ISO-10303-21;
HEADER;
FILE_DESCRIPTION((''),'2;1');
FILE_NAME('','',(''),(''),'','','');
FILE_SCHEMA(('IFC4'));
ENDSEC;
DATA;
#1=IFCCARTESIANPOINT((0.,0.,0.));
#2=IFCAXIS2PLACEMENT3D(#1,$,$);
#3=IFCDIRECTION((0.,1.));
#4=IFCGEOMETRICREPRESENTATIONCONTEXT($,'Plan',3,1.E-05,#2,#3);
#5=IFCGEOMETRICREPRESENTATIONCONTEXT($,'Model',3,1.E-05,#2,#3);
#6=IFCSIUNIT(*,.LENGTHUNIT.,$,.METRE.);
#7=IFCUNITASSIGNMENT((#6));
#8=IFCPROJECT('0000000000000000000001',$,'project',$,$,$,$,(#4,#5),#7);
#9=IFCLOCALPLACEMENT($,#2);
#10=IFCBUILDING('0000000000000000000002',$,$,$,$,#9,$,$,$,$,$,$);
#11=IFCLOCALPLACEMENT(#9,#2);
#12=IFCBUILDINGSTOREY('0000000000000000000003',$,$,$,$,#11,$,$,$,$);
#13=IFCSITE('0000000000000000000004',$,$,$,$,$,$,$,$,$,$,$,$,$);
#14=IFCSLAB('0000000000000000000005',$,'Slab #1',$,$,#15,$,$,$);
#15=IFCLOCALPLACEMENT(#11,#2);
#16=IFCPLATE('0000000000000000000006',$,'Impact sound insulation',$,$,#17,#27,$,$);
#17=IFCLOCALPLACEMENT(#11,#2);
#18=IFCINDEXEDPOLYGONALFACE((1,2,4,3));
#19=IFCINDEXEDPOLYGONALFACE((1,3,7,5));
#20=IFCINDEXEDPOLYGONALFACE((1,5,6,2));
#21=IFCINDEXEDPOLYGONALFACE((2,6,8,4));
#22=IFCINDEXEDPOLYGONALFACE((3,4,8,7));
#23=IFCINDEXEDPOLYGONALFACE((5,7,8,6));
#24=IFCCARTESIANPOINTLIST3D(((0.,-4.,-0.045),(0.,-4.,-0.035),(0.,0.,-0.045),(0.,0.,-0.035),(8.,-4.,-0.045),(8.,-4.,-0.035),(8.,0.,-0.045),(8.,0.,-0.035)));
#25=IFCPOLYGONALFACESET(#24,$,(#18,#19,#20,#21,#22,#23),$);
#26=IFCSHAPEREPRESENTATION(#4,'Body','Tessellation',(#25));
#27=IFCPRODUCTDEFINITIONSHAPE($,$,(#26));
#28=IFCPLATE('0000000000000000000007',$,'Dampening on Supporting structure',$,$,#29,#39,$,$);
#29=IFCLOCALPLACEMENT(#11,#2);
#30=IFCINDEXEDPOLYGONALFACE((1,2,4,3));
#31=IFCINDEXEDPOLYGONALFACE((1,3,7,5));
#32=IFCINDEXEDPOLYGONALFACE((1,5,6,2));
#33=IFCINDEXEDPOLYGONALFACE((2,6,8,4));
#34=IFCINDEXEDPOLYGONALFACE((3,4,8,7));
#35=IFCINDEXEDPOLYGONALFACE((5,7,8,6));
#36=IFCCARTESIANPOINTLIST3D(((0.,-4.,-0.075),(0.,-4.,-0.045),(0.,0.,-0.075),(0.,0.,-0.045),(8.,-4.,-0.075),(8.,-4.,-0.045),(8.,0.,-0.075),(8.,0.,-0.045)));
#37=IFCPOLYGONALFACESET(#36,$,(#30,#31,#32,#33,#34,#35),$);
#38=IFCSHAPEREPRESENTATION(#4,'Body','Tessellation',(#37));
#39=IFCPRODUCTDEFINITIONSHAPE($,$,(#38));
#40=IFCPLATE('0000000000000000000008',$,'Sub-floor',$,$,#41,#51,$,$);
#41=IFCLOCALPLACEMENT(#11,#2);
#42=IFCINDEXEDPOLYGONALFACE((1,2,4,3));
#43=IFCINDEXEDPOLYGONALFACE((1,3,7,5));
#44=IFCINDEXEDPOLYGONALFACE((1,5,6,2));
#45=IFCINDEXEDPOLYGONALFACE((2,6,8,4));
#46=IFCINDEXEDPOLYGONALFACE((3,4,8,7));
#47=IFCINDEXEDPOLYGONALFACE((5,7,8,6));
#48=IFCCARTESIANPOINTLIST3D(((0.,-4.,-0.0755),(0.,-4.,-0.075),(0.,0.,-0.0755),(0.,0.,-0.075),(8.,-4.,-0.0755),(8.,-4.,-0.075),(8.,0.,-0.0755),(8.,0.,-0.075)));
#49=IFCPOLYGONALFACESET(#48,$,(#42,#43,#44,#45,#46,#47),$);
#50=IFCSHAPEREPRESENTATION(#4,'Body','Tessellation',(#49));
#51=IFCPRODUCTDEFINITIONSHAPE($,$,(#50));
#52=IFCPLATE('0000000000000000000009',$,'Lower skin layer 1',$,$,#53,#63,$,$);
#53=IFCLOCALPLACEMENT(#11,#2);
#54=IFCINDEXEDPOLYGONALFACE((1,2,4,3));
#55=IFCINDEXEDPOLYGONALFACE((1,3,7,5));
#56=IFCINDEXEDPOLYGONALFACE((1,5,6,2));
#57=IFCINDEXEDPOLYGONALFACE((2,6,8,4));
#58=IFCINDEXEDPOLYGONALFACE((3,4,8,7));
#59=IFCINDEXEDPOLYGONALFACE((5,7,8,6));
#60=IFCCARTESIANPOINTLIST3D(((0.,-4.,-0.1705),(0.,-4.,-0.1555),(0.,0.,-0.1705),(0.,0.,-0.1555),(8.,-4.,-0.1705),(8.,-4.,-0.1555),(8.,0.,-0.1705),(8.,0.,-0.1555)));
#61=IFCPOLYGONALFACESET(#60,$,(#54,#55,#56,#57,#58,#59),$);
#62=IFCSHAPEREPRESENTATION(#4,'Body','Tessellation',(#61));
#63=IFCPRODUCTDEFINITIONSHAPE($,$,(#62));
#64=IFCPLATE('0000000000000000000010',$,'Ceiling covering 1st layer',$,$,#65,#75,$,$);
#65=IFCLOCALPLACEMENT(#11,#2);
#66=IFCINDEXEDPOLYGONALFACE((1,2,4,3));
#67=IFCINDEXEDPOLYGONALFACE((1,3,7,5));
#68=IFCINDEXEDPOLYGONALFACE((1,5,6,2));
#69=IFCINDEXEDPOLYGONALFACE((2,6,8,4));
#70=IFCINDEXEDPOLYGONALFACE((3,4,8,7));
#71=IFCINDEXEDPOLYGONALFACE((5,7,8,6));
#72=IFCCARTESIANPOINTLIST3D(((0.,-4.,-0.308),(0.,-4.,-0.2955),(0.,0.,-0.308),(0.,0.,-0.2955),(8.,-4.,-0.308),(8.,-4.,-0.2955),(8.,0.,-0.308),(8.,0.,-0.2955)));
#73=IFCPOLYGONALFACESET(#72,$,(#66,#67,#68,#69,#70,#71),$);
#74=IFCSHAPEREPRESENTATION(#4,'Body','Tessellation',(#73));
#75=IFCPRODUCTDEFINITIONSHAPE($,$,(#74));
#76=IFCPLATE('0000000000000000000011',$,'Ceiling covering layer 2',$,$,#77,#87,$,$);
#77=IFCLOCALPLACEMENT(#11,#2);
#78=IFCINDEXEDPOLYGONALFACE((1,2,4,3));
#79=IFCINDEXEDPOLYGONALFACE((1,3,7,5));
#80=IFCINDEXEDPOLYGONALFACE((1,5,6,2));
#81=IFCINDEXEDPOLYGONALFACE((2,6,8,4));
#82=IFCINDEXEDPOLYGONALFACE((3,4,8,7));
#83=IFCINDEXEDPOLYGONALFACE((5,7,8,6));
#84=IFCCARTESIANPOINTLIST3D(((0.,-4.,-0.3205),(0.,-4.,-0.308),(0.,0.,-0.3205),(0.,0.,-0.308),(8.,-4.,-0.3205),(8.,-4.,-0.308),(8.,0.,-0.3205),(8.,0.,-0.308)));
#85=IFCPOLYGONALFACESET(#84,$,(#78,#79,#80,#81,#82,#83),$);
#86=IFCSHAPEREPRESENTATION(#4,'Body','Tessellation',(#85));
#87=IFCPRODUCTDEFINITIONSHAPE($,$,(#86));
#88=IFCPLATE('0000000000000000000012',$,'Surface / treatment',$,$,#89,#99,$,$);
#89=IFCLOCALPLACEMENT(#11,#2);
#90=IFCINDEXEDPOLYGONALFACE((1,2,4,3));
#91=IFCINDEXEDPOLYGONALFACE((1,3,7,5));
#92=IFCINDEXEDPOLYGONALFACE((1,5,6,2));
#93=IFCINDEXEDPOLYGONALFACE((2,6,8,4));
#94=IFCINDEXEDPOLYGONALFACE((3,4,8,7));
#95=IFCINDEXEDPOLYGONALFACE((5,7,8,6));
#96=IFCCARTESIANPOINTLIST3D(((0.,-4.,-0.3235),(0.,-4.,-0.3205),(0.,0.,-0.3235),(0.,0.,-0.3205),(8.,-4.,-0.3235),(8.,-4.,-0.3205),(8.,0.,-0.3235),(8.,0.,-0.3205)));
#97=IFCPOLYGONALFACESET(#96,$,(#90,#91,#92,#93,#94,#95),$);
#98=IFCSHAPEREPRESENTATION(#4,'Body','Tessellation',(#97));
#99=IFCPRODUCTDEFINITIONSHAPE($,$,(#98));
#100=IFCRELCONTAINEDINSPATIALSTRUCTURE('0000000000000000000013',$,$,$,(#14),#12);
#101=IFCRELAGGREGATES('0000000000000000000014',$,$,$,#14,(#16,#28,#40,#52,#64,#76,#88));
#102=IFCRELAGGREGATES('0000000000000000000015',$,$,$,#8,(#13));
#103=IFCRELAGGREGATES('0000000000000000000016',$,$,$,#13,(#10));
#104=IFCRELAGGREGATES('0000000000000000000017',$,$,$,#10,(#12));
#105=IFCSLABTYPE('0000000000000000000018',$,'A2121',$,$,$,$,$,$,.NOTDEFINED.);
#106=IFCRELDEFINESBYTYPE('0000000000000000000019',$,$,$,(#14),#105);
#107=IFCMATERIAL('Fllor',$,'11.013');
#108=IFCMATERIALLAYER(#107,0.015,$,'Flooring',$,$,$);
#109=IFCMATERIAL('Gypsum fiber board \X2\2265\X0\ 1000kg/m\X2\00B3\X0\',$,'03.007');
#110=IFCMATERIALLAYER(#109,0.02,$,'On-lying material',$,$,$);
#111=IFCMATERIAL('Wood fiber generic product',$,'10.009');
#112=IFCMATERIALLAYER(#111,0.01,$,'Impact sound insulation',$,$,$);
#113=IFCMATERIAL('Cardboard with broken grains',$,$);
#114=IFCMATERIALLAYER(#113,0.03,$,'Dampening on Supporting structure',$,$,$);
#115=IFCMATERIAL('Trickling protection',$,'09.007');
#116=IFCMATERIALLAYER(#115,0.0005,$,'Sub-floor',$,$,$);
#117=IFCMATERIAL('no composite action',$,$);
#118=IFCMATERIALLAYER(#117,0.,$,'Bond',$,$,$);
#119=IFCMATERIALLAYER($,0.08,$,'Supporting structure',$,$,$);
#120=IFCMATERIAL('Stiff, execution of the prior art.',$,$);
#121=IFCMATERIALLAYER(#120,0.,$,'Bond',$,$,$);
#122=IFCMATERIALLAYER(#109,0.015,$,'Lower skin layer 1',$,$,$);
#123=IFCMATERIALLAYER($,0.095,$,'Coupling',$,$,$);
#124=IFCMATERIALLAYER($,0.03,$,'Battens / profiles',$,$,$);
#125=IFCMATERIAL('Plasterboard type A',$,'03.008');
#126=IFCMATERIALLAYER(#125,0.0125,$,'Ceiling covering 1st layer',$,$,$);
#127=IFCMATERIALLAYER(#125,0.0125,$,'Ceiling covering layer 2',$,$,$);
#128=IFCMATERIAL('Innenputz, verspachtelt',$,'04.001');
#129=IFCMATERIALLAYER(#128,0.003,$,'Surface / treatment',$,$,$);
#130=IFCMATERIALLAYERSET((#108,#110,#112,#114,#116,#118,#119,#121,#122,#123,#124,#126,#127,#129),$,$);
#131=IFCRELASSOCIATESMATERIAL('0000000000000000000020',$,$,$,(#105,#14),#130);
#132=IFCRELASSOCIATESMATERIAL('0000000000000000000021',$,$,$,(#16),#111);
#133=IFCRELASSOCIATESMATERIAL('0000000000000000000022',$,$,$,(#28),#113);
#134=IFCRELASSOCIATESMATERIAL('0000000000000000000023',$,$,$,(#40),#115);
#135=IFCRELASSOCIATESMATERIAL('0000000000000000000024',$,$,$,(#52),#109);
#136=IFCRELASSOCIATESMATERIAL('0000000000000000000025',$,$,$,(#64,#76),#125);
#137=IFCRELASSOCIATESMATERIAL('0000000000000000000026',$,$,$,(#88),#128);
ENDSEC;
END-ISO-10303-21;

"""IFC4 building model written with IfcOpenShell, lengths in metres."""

from ifc_helpers import new_model, si_unit, direction, frame, frame_2d, origin, place, context, project, spatial, rectangle, extrude, material, layer, layer_set, type_object, element, aggregate, save


model = new_model("IFC4")

# Units and contexts
plan_context = context("Plan", 3, precision=1e-05, world=origin(), true_north=direction((0.0, 1.0)))
model_context = context("Model", 3, precision=1e-05, world=origin(), true_north=direction((0.0, 1.0)))
ifc_project = project(units=[si_unit("LENGTHUNIT", "METRE")], contexts=[plan_context, model_context])

# Site, building, storey
site = spatial("IfcSite", under=ifc_project)
building_placement = place(None, origin())
building = spatial("IfcBuilding", under=site, at=building_placement)
storey_placement = place(building_placement, origin())
storey = spatial("IfcBuildingStorey", under=building, at=storey_placement)

# Slab, plates
ifc_material_1 = material(Name="Fllor", Category="11.013")
ifc_layer_1 = layer(ifc_material_1, 0.015, Name="Flooring")
ifc_material_2 = material(Name="Gypsum fiber board ≥ 1000kg/m³", Category="03.007")
ifc_layer_2 = layer(ifc_material_2, 0.02, Name="On-lying material")
ifc_material_3 = material(Name="Wood fiber generic product", Category="10.009")
ifc_layer_3 = layer(ifc_material_3, 0.01, Name="Impact sound insulation")
ifc_material_4 = material(Name="Cardboard with broken grains")
ifc_layer_4 = layer(ifc_material_4, 0.03, Name="Dampening on Supporting structure")
ifc_material_5 = material(Name="Trickling protection", Category="09.007")
ifc_layer_5 = layer(ifc_material_5, 0.0005, Name="Sub-floor")
ifc_material_6 = material(Name="no composite action")
ifc_layer_6 = layer(ifc_material_6, 0.0, Name="Bond")
ifc_layer_7 = layer(None, 0.08, Name="Supporting structure")
ifc_material_7 = material(Name="Stiff, execution of the prior art.")
ifc_layer_8 = layer(ifc_material_7, 0.0, Name="Bond")
ifc_layer_9 = layer(ifc_material_2, 0.015, Name="Lower skin layer 1")
ifc_layer_10 = layer(None, 0.095, Name="Coupling")
ifc_layer_11 = layer(None, 0.03, Name="Battens / profiles")
ifc_material_8 = material(Name="Plasterboard type A", Category="03.008")
ifc_layer_12 = layer(ifc_material_8, 0.0125, Name="Ceiling covering 1st layer")
ifc_layer_13 = layer(ifc_material_8, 0.0125, Name="Ceiling covering layer 2")
ifc_material_9 = material(Name="Innenputz, verspachtelt", Category="04.001")
ifc_layer_14 = layer(ifc_material_9, 0.003, Name="Surface / treatment")
ifc_layer_set = layer_set([ifc_layer_1, ifc_layer_2, ifc_layer_3, ifc_layer_4, ifc_layer_5, ifc_layer_6, ifc_layer_7, ifc_layer_8, ifc_layer_9, ifc_layer_10, ifc_layer_11, ifc_layer_12, ifc_layer_13, ifc_layer_14])
slab_type = type_object("IfcSlabType", Name="A2121", PredefinedType="NOTDEFINED", material=ifc_layer_set)
slab_placement = place(None, frame((0.0, 0.0, 0.0), z_axis=(0.0, 0.0, -1.0), x_axis=(1.0, 0.0, 0.0)))
slab = element("IfcSlab", 1, at=slab_placement, inside=storey, type_object=slab_type, material=ifc_layer_set, Name="Slab #1")
plate_1_placement = place(slab_placement, origin())
plate_1 = element("IfcPlate", 2, at=plate_1_placement, material=ifc_material_3, Name="Impact sound insulation", context=plan_context, shape_type="SweptSolid", body=[
    extrude(rectangle(XDim=8.0, YDim=4.0, at=frame_2d((4.0, 2.0), x_axis=(1.0, 0.0))), frame((0.0, 0.0, 0.035), z_axis=(0.0, 0.0, 1.0), x_axis=(1.0, 0.0, 0.0)), (0.0, 0.0, 1.0), 0.01),
])
plate_2_placement = place(slab_placement, origin())
plate_2 = element("IfcPlate", 3, at=plate_2_placement, material=ifc_material_4, Name="Dampening on Supporting structure", context=plan_context, shape_type="SweptSolid", body=[
    extrude(rectangle(XDim=8.0, YDim=4.0, at=frame_2d((4.0, 2.0), x_axis=(1.0, 0.0))), frame((0.0, 0.0, 0.045), z_axis=(0.0, 0.0, 1.0), x_axis=(1.0, 0.0, 0.0)), (0.0, 0.0, 1.0), 0.03),
])
plate_3_placement = place(slab_placement, origin())
plate_3 = element("IfcPlate", 4, at=plate_3_placement, material=ifc_material_5, Name="Sub-floor", context=plan_context, shape_type="SweptSolid", body=[
    extrude(rectangle(XDim=8.0, YDim=4.0, at=frame_2d((4.0, 2.0), x_axis=(1.0, 0.0))), frame((0.0, 0.0, 0.075), z_axis=(0.0, 0.0, 1.0), x_axis=(1.0, 0.0, 0.0)), (0.0, 0.0, 1.0), 0.0005),
])
plate_4_placement = place(slab_placement, origin())
plate_4 = element("IfcPlate", 5, at=plate_4_placement, material=ifc_material_2, Name="Lower skin layer 1", context=plan_context, shape_type="SweptSolid", body=[
    extrude(rectangle(XDim=8.0, YDim=4.0, at=frame_2d((4.0, 2.0), x_axis=(1.0, 0.0))), frame((0.0, 0.0, 0.1555), z_axis=(0.0, 0.0, 1.0), x_axis=(1.0, 0.0, 0.0)), (0.0, 0.0, 1.0), 0.015),
])
plate_5_placement = place(slab_placement, origin())
plate_5 = element("IfcPlate", 6, at=plate_5_placement, material=ifc_material_8, Name="Ceiling covering 1st layer", context=plan_context, shape_type="SweptSolid", body=[
    extrude(rectangle(XDim=8.0, YDim=4.0, at=frame_2d((4.0, 2.0), x_axis=(1.0, 0.0))), frame((0.0, 0.0, 0.2955), z_axis=(0.0, 0.0, 1.0), x_axis=(1.0, 0.0, 0.0)), (0.0, 0.0, 1.0), 0.0125),
])
plate_6_placement = place(slab_placement, origin())
plate_6 = element("IfcPlate", 7, at=plate_6_placement, material=ifc_material_8, Name="Ceiling covering layer 2", context=plan_context, shape_type="SweptSolid", body=[
    extrude(rectangle(XDim=8.0, YDim=4.0, at=frame_2d((4.0, 2.0), x_axis=(1.0, 0.0))), frame((0.0, 0.0, 0.308), z_axis=(0.0, 0.0, 1.0), x_axis=(1.0, 0.0, 0.0)), (0.0, 0.0, 1.0), 0.0125),
])
plate_7_placement = place(slab_placement, origin())
plate_7 = element("IfcPlate", 8, at=plate_7_placement, material=ifc_material_9, Name="Surface / treatment", context=plan_context, shape_type="SweptSolid", body=[
    extrude(rectangle(XDim=8.0, YDim=4.0, at=frame_2d((4.0, 2.0), x_axis=(1.0, 0.0))), frame((0.0, 0.0, 0.3205), z_axis=(0.0, 0.0, 1.0), x_axis=(1.0, 0.0, 0.0)), (0.0, 0.0, 1.0), 0.003),
])
aggregate(slab, [plate_1, plate_2, plate_3, plate_4, plate_5, plate_6, plate_7])

save(model, "model.ifc")
